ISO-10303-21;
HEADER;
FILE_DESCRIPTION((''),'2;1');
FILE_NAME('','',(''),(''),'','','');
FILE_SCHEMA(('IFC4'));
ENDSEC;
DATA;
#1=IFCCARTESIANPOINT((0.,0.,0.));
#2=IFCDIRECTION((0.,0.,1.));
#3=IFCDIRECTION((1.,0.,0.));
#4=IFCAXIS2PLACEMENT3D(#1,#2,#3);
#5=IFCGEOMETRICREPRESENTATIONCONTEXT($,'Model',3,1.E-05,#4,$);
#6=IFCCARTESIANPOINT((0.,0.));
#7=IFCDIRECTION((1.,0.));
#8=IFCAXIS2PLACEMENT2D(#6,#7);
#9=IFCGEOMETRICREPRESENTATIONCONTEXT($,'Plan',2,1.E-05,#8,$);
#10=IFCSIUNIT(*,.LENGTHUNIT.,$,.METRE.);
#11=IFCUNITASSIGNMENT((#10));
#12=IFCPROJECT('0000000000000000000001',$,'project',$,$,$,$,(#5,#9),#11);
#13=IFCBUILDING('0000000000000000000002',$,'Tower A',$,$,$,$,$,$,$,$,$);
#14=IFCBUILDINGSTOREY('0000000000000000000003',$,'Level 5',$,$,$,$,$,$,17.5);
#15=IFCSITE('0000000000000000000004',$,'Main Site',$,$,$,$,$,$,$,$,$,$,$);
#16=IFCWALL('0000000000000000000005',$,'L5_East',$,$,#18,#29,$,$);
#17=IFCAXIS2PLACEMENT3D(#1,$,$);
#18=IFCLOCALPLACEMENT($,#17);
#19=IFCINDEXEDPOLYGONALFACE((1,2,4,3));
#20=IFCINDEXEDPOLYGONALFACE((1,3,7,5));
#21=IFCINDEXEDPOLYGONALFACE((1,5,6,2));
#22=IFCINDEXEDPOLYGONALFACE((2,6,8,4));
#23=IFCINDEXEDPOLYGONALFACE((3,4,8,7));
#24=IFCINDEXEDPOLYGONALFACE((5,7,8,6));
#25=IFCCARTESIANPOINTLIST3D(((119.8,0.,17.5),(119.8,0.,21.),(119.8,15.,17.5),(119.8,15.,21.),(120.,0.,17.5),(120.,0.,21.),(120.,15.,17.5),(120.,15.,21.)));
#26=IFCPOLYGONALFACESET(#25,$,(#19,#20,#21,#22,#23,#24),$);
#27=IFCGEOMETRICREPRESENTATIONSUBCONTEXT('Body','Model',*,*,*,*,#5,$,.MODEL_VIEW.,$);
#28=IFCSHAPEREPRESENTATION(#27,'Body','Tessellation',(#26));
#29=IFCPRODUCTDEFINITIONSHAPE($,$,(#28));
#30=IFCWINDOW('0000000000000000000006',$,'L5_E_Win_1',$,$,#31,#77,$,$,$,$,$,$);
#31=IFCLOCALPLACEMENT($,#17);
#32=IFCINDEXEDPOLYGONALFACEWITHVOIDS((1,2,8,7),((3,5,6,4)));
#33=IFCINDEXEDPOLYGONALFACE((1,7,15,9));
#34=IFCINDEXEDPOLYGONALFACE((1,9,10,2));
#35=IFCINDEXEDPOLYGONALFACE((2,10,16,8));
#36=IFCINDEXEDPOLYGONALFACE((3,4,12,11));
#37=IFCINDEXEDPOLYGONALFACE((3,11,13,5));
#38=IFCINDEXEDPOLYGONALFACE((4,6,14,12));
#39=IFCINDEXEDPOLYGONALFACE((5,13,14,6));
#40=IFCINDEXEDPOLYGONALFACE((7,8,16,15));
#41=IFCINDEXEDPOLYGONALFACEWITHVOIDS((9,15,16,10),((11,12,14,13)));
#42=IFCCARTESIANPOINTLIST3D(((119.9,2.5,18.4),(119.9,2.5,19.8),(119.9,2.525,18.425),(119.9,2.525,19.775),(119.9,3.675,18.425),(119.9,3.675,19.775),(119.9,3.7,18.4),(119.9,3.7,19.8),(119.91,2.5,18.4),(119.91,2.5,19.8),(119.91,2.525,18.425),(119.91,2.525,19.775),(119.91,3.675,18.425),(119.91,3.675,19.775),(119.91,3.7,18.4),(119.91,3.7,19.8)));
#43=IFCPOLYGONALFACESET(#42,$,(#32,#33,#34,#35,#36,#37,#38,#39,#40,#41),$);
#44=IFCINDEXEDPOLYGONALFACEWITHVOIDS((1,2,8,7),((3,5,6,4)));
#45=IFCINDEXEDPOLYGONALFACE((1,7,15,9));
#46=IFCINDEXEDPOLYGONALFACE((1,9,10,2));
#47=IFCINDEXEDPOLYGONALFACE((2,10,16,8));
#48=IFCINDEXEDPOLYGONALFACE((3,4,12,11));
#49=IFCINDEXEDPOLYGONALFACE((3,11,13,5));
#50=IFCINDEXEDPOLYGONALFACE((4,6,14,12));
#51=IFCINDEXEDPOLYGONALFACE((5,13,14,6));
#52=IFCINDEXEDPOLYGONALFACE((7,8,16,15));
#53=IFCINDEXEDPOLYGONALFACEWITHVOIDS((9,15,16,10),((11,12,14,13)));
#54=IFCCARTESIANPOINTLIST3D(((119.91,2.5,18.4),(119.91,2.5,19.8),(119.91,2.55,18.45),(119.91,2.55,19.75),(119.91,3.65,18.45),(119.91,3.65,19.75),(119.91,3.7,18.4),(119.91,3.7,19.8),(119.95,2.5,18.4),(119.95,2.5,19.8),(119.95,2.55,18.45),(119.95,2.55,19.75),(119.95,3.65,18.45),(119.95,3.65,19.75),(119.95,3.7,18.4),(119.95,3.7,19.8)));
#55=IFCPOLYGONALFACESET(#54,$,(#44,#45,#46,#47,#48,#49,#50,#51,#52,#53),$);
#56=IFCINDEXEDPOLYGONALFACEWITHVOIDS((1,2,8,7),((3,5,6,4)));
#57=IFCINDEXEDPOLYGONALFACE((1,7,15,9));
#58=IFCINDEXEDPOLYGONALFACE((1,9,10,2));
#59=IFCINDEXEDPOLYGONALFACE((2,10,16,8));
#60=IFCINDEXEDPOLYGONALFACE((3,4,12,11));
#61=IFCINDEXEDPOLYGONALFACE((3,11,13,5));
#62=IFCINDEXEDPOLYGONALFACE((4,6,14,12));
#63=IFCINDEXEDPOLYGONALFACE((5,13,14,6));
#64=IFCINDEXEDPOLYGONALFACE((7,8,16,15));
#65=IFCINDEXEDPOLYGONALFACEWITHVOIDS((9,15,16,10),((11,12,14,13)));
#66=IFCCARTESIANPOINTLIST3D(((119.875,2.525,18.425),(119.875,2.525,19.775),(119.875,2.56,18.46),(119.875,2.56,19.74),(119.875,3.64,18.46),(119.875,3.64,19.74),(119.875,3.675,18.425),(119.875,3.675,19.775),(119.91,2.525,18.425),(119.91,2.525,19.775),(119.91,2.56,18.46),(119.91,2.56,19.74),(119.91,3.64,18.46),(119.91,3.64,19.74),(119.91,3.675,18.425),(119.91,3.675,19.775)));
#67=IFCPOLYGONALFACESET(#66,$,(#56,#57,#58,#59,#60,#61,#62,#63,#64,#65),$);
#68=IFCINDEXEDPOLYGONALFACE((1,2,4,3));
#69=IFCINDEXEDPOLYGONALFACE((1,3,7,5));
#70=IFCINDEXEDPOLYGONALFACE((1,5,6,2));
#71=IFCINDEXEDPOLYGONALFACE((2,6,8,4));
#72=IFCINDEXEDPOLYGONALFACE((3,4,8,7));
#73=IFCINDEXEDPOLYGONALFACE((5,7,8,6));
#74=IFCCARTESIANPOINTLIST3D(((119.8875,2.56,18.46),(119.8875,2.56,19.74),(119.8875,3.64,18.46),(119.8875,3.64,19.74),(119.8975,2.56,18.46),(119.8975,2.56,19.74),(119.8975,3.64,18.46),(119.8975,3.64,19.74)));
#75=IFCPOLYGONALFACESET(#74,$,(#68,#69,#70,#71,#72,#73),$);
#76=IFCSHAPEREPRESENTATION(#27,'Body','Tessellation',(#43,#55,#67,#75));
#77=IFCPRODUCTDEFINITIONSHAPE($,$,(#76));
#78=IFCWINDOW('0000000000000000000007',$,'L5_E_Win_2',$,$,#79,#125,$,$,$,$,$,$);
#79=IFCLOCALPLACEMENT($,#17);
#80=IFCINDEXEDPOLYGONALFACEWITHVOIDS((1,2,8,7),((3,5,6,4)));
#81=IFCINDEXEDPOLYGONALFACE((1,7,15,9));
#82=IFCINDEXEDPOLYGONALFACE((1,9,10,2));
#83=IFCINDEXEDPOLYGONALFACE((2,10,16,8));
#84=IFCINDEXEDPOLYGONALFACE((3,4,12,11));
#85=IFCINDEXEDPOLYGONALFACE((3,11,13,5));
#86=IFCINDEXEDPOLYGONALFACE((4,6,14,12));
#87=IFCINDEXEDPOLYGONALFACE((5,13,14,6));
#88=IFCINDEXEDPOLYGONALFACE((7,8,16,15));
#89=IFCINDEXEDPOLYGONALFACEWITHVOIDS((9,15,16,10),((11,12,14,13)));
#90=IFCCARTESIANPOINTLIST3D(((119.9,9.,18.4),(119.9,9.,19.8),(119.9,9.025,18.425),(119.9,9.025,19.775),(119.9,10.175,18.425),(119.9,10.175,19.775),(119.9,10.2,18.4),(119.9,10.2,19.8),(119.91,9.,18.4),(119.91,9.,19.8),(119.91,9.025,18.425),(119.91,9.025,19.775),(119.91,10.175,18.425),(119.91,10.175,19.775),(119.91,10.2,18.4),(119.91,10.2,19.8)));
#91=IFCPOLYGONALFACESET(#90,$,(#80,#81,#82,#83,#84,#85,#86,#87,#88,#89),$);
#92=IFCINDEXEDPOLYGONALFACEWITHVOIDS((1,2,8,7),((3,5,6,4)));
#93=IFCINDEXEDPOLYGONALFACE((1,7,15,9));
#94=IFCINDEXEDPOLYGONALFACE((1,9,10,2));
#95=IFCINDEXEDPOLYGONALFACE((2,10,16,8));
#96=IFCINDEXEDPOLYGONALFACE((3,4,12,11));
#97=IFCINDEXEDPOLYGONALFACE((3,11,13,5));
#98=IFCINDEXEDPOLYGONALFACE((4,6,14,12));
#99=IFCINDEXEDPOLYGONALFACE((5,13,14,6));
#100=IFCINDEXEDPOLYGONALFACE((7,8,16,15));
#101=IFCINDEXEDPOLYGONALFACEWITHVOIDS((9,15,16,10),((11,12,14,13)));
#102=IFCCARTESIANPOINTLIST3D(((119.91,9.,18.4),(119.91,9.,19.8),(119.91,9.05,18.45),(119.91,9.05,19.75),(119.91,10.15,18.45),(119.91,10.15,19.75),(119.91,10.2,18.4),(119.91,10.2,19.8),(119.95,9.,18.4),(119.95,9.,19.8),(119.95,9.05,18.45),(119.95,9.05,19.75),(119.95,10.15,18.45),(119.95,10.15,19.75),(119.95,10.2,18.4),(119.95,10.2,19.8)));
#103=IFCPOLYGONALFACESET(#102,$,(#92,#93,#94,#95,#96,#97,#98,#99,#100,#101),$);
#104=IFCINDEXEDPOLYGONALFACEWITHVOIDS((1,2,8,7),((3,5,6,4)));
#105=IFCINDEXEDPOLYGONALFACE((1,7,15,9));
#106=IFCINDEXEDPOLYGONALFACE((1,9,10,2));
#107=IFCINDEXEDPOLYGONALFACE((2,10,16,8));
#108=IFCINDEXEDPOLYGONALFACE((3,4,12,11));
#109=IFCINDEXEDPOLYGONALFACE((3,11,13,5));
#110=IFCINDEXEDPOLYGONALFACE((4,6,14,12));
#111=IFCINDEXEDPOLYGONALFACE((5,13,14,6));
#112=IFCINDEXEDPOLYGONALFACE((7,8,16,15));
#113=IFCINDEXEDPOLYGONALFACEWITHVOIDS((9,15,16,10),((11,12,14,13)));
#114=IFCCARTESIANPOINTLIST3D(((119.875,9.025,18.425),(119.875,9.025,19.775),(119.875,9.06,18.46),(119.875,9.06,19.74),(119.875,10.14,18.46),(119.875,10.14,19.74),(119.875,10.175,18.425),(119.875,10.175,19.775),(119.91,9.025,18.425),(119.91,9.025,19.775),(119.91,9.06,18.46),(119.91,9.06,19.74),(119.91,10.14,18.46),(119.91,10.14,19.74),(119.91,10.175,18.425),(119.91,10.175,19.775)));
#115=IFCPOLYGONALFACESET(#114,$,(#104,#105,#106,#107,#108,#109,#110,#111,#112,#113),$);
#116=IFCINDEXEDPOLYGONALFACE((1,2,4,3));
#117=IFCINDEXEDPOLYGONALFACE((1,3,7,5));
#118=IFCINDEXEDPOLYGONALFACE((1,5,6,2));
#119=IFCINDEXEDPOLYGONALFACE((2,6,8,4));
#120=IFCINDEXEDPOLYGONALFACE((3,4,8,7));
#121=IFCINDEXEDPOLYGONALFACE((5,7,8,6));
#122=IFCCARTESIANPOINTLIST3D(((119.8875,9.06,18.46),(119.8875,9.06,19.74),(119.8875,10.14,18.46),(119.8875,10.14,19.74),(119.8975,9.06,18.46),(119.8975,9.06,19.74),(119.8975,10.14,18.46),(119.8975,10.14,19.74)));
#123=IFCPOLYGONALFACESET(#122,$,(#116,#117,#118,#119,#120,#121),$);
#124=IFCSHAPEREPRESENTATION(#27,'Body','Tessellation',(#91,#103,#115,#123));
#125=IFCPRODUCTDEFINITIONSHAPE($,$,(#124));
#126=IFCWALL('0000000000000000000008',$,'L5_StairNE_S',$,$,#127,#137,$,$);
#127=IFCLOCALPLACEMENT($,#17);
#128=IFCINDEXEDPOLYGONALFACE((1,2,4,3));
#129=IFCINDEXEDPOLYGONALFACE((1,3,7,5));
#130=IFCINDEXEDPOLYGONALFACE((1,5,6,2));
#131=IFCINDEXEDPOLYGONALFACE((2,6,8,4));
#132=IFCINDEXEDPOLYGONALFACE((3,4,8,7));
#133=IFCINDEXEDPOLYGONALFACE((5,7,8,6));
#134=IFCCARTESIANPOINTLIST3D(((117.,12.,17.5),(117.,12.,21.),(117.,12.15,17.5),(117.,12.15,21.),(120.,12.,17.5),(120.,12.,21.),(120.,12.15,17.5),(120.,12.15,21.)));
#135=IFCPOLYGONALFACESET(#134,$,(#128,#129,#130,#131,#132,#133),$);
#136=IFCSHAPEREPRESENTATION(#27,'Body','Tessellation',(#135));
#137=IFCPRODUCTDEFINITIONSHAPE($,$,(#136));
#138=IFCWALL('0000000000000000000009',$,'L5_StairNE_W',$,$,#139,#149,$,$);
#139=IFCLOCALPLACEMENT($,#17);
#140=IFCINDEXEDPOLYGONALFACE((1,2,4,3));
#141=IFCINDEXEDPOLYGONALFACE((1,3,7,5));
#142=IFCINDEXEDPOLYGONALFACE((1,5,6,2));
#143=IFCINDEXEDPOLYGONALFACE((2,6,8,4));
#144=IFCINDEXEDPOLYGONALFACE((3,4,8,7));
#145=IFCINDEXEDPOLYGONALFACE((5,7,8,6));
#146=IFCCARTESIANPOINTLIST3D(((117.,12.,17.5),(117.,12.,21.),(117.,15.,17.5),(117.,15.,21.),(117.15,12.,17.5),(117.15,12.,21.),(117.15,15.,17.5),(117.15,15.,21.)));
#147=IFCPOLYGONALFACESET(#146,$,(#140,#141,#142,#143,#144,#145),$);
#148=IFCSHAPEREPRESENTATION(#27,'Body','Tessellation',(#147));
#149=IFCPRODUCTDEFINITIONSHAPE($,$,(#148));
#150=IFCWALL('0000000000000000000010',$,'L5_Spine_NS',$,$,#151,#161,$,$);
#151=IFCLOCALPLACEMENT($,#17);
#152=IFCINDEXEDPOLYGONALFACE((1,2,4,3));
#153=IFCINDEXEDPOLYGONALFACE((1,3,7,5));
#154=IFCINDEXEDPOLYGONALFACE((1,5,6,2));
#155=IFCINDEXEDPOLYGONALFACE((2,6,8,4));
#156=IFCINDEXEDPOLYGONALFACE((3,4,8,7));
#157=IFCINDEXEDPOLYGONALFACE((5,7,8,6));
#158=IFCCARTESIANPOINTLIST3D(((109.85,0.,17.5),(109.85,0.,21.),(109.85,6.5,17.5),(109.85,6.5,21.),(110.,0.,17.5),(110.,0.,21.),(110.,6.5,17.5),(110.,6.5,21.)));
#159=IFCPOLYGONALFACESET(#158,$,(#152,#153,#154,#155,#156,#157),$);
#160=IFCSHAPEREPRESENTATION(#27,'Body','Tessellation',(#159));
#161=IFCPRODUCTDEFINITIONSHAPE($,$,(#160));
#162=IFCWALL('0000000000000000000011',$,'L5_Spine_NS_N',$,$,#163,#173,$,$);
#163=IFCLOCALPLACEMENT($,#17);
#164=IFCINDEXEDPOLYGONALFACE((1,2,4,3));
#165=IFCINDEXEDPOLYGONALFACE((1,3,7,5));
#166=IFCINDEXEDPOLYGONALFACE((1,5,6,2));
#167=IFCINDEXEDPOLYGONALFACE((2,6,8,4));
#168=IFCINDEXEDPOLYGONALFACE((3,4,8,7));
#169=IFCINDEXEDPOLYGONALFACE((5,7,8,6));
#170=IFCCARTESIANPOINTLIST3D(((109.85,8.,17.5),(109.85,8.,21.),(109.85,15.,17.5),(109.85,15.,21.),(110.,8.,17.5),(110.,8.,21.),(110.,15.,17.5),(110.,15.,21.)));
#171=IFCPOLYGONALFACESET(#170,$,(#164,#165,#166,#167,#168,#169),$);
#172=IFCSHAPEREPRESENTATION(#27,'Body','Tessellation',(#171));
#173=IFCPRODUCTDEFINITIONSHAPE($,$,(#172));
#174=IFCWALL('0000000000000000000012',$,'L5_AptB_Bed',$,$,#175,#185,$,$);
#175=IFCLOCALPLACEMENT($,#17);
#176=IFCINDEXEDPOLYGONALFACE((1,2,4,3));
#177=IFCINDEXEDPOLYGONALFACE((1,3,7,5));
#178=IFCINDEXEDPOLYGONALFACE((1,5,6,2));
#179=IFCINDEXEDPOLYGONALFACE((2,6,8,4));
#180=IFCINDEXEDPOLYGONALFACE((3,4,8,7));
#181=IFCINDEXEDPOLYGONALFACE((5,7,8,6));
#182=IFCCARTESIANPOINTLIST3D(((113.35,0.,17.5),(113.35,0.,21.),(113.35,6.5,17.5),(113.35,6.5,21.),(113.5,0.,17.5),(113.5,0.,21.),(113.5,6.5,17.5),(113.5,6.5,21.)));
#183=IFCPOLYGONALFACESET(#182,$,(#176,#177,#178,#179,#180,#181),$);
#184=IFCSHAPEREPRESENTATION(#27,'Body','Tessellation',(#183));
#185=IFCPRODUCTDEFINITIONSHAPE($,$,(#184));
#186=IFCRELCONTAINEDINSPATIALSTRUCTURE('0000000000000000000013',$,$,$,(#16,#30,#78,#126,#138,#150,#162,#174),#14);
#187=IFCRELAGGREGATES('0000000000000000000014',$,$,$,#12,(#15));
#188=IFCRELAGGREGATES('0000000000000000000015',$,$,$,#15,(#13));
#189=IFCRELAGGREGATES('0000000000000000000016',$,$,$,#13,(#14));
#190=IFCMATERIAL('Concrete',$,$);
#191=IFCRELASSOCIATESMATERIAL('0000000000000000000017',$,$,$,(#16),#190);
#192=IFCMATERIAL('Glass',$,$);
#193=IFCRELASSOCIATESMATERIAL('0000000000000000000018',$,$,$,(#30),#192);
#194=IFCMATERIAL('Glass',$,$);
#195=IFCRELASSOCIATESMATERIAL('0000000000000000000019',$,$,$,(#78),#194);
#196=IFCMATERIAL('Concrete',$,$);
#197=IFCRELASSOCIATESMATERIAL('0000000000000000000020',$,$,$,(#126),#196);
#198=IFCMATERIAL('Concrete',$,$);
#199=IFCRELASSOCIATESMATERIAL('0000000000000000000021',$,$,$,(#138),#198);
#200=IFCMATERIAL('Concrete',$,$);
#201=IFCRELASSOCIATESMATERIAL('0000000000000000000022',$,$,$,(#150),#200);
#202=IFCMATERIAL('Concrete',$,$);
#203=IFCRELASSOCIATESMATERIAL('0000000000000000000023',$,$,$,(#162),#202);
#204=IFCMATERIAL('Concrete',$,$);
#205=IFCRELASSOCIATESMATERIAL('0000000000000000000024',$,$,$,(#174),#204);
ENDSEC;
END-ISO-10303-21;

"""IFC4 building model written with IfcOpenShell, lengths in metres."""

from ifc_helpers import new_model, si_unit, frame, origin_with_axes, origin_2d_with_axis, place, context, subcontext, project, spatial, line, indexed_curve, outline, extrude, material, element, fill, save


model = new_model("IFC4")

# Units and contexts
model_context = context("Model", 3, precision=1e-05, world=origin_with_axes())
plan_context = context("Plan", 2, precision=1e-05, world=origin_2d_with_axis())
body_context = subcontext(model_context, "Body", "Model", "MODEL_VIEW")
ifc_project = project(units=[si_unit("LENGTHUNIT", "METRE")], contexts=[model_context, plan_context])

# Site, building, storey
site = spatial("IfcSite", under=ifc_project, Name="Main Site")
building = spatial("IfcBuilding", under=site, Name="Tower A")
storey = spatial("IfcBuildingStorey", under=building, Name="Level 5", Elevation=17.5)

# Wall, openings, windows
ifc_material_1 = material(Name="Concrete")
wall_1_placement = place(None, frame((120.0, 0.0, 17.5), z_axis=(0.0, 0.0, 1.0), x_axis=(0.0, 1.0, 0.0)))
wall_1 = element("IfcWall", 1, at=wall_1_placement, inside=storey, material=ifc_material_1, Name="L5_East", context=body_context, shape_type="SweptSolid", body=[
    extrude(outline(indexed_curve([(0.0, 0.0), (0.0, 0.2), (15.0, 0.2), (15.0, 0.0), (0.0, 0.0)], self_intersect=False)), origin_with_axes(), (0.0, 0.0, 1.0), 3.5),
])
opening_1_placement = place(wall_1_placement, frame((2.5, 0.0, 0.9), z_axis=(0.0, 0.0, 1.0), x_axis=(0.0, -1.0, 0.0)))
opening_1 = element("IfcOpeningElement", 2, at=opening_1_placement, cuts=wall_1, context=body_context, shape_type="SweptSolid", body=[
    extrude(outline(indexed_curve([(0.0, 0.0), (0.0, 0.25), (1.2, 0.25), (1.2, 0.0), (0.0, 0.0)], self_intersect=False)), origin_with_axes(), (0.0, 0.0, 1.0), 1.4),
])
opening_2_placement = place(wall_1_placement, frame((9.0, 0.0, 0.9), z_axis=(0.0, 0.0, 1.0), x_axis=(0.0, -1.0, 0.0)))
opening_2 = element("IfcOpeningElement", 3, at=opening_2_placement, cuts=wall_1, context=body_context, shape_type="SweptSolid", body=[
    extrude(outline(indexed_curve([(0.0, 0.0), (0.0, 0.25), (1.2, 0.25), (1.2, 0.0), (0.0, 0.0)], self_intersect=False)), origin_with_axes(), (0.0, 0.0, 1.0), 1.4),
])
ifc_material_2 = material(Name="Glass")
window_1_placement = place(None, frame((120.0, 2.5, 18.4), z_axis=(0.0, 0.0, 1.0), x_axis=(0.0, 1.0, 0.0)))
window_1 = element("IfcWindow", 4, at=window_1_placement, inside=storey, material=ifc_material_2, Name="L5_E_Win_1", context=body_context, shape_type="SweptSolid", body=[
    extrude(outline(indexed_curve([(0.0, 0.0), (1.2, 0.0), (1.2, 1.4), (0.0, 1.4)], segments=[line(1, 2, 3, 4, 1)]), holes=[indexed_curve([(0.025, 0.025), (1.175, 0.025), (1.175, 1.375), (0.025, 1.375)], segments=[line(1, 2, 3, 4, 1)])]), frame((0.0, 0.09, 0.0), z_axis=(0.0, -1.0, 0.0), x_axis=(1.0, 0.0, 0.0)), (0.0, 0.0, -1.0), 0.01),
    extrude(outline(indexed_curve([(0.0, 0.0), (1.2, 0.0), (1.2, 1.4), (0.0, 1.4)], segments=[line(1, 2, 3, 4, 1)]), holes=[indexed_curve([(0.05, 0.05), (1.15, 0.05), (1.15, 1.35), (0.05, 1.35)], segments=[line(1, 2, 3, 4, 1)])]), frame((0.0, 0.05, 0.0), z_axis=(0.0, -1.0, 0.0), x_axis=(1.0, 0.0, 0.0)), (0.0, 0.0, -1.0), 0.04),
    extrude(outline(indexed_curve([(0.0, 0.0), (1.15, 0.0), (1.15, 1.35), (0.0, 1.35)], segments=[line(1, 2, 3, 4, 1)]), holes=[indexed_curve([(0.035, 0.035), (1.115, 0.035), (1.115, 1.315), (0.035, 1.315)], segments=[line(1, 2, 3, 4, 1)])]), frame((0.025, 0.09, 0.025), z_axis=(0.0, -1.0, 0.0), x_axis=(1.0, 0.0, 0.0)), (0.0, 0.0, -1.0), 0.035),
    extrude(outline(indexed_curve([(0.035, 0.035), (1.115, 0.035), (1.115, 1.315), (0.035, 1.315)], segments=[line(1, 2, 3, 4, 1)])), frame((0.025, 0.1025, 0.025), z_axis=(0.0, -1.0, 0.0), x_axis=(1.0, 0.0, 0.0)), (0.0, 0.0, -1.0), 0.01),
])
fill(opening_1, window_1)
ifc_material_3 = material(Name="Glass")
window_2_placement = place(None, frame((120.0, 9.0, 18.4), z_axis=(0.0, 0.0, 1.0), x_axis=(0.0, 1.0, 0.0)))
window_2 = element("IfcWindow", 5, at=window_2_placement, inside=storey, material=ifc_material_3, Name="L5_E_Win_2", context=body_context, shape_type="SweptSolid", body=[
    extrude(outline(indexed_curve([(0.0, 0.0), (1.2, 0.0), (1.2, 1.4), (0.0, 1.4)], segments=[line(1, 2, 3, 4, 1)]), holes=[indexed_curve([(0.025, 0.025), (1.175, 0.025), (1.175, 1.375), (0.025, 1.375)], segments=[line(1, 2, 3, 4, 1)])]), frame((0.0, 0.09, 0.0), z_axis=(0.0, -1.0, 0.0), x_axis=(1.0, 0.0, 0.0)), (0.0, 0.0, -1.0), 0.01),
    extrude(outline(indexed_curve([(0.0, 0.0), (1.2, 0.0), (1.2, 1.4), (0.0, 1.4)], segments=[line(1, 2, 3, 4, 1)]), holes=[indexed_curve([(0.05, 0.05), (1.15, 0.05), (1.15, 1.35), (0.05, 1.35)], segments=[line(1, 2, 3, 4, 1)])]), frame((0.0, 0.05, 0.0), z_axis=(0.0, -1.0, 0.0), x_axis=(1.0, 0.0, 0.0)), (0.0, 0.0, -1.0), 0.04),
    extrude(outline(indexed_curve([(0.0, 0.0), (1.15, 0.0), (1.15, 1.35), (0.0, 1.35)], segments=[line(1, 2, 3, 4, 1)]), holes=[indexed_curve([(0.035, 0.035), (1.115, 0.035), (1.115, 1.315), (0.035, 1.315)], segments=[line(1, 2, 3, 4, 1)])]), frame((0.025, 0.09, 0.025), z_axis=(0.0, -1.0, 0.0), x_axis=(1.0, 0.0, 0.0)), (0.0, 0.0, -1.0), 0.035),
    extrude(outline(indexed_curve([(0.035, 0.035), (1.115, 0.035), (1.115, 1.315), (0.035, 1.315)], segments=[line(1, 2, 3, 4, 1)])), frame((0.025, 0.1025, 0.025), z_axis=(0.0, -1.0, 0.0), x_axis=(1.0, 0.0, 0.0)), (0.0, 0.0, -1.0), 0.01),
])
fill(opening_2, window_2)

# Walls
ifc_material_4 = material(Name="Concrete")
wall_2_placement = place(None, frame((117.0, 12.0, 17.5), z_axis=(0.0, 0.0, 1.0), x_axis=(1.0, 0.0, 0.0)))
element("IfcWall", 6, at=wall_2_placement, inside=storey, material=ifc_material_4, Name="L5_StairNE_S", context=body_context, shape_type="SweptSolid", body=[
    extrude(outline(indexed_curve([(0.0, 0.0), (0.0, 0.15), (3.0, 0.15), (3.0, 0.0), (0.0, 0.0)], self_intersect=False)), origin_with_axes(), (0.0, 0.0, 1.0), 3.5),
])
ifc_material_5 = material(Name="Concrete")
wall_3_placement = place(None, frame((117.0, 15.0, 17.5), z_axis=(0.0, 0.0, 1.0), x_axis=(0.0, -1.0, 0.0)))
element("IfcWall", 7, at=wall_3_placement, inside=storey, material=ifc_material_5, Name="L5_StairNE_W", context=body_context, shape_type="SweptSolid", body=[
    extrude(outline(indexed_curve([(0.0, 0.0), (0.0, 0.15), (3.0, 0.15), (3.0, 0.0), (0.0, 0.0)], self_intersect=False)), origin_with_axes(), (0.0, 0.0, 1.0), 3.5),
])
ifc_material_6 = material(Name="Concrete")
wall_4_placement = place(None, frame((110.0, 0.0, 17.5), z_axis=(0.0, 0.0, 1.0), x_axis=(0.0, 1.0, 0.0)))
element("IfcWall", 8, at=wall_4_placement, inside=storey, material=ifc_material_6, Name="L5_Spine_NS", context=body_context, shape_type="SweptSolid", body=[
    extrude(outline(indexed_curve([(0.0, 0.0), (0.0, 0.15), (6.5, 0.15), (6.5, 0.0), (0.0, 0.0)], self_intersect=False)), origin_with_axes(), (0.0, 0.0, 1.0), 3.5),
])
ifc_material_7 = material(Name="Concrete")
wall_5_placement = place(None, frame((110.0, 8.0, 17.5), z_axis=(0.0, 0.0, 1.0), x_axis=(0.0, 1.0, 0.0)))
element("IfcWall", 9, at=wall_5_placement, inside=storey, material=ifc_material_7, Name="L5_Spine_NS_N", context=body_context, shape_type="SweptSolid", body=[
    extrude(outline(indexed_curve([(0.0, 0.0), (0.0, 0.15), (7.0, 0.15), (7.0, 0.0), (0.0, 0.0)], self_intersect=False)), origin_with_axes(), (0.0, 0.0, 1.0), 3.5),
])
ifc_material_8 = material(Name="Concrete")
wall_6_placement = place(None, frame((113.5, 0.0, 17.5), z_axis=(0.0, 0.0, 1.0), x_axis=(0.0, 1.0, 0.0)))
element("IfcWall", 10, at=wall_6_placement, inside=storey, material=ifc_material_8, Name="L5_AptB_Bed", context=body_context, shape_type="SweptSolid", body=[
    extrude(outline(indexed_curve([(0.0, 0.0), (0.0, 0.15), (6.5, 0.15), (6.5, 0.0), (0.0, 0.0)], self_intersect=False)), origin_with_axes(), (0.0, 0.0, 1.0), 3.5),
])

save(model, "model.ifc")
